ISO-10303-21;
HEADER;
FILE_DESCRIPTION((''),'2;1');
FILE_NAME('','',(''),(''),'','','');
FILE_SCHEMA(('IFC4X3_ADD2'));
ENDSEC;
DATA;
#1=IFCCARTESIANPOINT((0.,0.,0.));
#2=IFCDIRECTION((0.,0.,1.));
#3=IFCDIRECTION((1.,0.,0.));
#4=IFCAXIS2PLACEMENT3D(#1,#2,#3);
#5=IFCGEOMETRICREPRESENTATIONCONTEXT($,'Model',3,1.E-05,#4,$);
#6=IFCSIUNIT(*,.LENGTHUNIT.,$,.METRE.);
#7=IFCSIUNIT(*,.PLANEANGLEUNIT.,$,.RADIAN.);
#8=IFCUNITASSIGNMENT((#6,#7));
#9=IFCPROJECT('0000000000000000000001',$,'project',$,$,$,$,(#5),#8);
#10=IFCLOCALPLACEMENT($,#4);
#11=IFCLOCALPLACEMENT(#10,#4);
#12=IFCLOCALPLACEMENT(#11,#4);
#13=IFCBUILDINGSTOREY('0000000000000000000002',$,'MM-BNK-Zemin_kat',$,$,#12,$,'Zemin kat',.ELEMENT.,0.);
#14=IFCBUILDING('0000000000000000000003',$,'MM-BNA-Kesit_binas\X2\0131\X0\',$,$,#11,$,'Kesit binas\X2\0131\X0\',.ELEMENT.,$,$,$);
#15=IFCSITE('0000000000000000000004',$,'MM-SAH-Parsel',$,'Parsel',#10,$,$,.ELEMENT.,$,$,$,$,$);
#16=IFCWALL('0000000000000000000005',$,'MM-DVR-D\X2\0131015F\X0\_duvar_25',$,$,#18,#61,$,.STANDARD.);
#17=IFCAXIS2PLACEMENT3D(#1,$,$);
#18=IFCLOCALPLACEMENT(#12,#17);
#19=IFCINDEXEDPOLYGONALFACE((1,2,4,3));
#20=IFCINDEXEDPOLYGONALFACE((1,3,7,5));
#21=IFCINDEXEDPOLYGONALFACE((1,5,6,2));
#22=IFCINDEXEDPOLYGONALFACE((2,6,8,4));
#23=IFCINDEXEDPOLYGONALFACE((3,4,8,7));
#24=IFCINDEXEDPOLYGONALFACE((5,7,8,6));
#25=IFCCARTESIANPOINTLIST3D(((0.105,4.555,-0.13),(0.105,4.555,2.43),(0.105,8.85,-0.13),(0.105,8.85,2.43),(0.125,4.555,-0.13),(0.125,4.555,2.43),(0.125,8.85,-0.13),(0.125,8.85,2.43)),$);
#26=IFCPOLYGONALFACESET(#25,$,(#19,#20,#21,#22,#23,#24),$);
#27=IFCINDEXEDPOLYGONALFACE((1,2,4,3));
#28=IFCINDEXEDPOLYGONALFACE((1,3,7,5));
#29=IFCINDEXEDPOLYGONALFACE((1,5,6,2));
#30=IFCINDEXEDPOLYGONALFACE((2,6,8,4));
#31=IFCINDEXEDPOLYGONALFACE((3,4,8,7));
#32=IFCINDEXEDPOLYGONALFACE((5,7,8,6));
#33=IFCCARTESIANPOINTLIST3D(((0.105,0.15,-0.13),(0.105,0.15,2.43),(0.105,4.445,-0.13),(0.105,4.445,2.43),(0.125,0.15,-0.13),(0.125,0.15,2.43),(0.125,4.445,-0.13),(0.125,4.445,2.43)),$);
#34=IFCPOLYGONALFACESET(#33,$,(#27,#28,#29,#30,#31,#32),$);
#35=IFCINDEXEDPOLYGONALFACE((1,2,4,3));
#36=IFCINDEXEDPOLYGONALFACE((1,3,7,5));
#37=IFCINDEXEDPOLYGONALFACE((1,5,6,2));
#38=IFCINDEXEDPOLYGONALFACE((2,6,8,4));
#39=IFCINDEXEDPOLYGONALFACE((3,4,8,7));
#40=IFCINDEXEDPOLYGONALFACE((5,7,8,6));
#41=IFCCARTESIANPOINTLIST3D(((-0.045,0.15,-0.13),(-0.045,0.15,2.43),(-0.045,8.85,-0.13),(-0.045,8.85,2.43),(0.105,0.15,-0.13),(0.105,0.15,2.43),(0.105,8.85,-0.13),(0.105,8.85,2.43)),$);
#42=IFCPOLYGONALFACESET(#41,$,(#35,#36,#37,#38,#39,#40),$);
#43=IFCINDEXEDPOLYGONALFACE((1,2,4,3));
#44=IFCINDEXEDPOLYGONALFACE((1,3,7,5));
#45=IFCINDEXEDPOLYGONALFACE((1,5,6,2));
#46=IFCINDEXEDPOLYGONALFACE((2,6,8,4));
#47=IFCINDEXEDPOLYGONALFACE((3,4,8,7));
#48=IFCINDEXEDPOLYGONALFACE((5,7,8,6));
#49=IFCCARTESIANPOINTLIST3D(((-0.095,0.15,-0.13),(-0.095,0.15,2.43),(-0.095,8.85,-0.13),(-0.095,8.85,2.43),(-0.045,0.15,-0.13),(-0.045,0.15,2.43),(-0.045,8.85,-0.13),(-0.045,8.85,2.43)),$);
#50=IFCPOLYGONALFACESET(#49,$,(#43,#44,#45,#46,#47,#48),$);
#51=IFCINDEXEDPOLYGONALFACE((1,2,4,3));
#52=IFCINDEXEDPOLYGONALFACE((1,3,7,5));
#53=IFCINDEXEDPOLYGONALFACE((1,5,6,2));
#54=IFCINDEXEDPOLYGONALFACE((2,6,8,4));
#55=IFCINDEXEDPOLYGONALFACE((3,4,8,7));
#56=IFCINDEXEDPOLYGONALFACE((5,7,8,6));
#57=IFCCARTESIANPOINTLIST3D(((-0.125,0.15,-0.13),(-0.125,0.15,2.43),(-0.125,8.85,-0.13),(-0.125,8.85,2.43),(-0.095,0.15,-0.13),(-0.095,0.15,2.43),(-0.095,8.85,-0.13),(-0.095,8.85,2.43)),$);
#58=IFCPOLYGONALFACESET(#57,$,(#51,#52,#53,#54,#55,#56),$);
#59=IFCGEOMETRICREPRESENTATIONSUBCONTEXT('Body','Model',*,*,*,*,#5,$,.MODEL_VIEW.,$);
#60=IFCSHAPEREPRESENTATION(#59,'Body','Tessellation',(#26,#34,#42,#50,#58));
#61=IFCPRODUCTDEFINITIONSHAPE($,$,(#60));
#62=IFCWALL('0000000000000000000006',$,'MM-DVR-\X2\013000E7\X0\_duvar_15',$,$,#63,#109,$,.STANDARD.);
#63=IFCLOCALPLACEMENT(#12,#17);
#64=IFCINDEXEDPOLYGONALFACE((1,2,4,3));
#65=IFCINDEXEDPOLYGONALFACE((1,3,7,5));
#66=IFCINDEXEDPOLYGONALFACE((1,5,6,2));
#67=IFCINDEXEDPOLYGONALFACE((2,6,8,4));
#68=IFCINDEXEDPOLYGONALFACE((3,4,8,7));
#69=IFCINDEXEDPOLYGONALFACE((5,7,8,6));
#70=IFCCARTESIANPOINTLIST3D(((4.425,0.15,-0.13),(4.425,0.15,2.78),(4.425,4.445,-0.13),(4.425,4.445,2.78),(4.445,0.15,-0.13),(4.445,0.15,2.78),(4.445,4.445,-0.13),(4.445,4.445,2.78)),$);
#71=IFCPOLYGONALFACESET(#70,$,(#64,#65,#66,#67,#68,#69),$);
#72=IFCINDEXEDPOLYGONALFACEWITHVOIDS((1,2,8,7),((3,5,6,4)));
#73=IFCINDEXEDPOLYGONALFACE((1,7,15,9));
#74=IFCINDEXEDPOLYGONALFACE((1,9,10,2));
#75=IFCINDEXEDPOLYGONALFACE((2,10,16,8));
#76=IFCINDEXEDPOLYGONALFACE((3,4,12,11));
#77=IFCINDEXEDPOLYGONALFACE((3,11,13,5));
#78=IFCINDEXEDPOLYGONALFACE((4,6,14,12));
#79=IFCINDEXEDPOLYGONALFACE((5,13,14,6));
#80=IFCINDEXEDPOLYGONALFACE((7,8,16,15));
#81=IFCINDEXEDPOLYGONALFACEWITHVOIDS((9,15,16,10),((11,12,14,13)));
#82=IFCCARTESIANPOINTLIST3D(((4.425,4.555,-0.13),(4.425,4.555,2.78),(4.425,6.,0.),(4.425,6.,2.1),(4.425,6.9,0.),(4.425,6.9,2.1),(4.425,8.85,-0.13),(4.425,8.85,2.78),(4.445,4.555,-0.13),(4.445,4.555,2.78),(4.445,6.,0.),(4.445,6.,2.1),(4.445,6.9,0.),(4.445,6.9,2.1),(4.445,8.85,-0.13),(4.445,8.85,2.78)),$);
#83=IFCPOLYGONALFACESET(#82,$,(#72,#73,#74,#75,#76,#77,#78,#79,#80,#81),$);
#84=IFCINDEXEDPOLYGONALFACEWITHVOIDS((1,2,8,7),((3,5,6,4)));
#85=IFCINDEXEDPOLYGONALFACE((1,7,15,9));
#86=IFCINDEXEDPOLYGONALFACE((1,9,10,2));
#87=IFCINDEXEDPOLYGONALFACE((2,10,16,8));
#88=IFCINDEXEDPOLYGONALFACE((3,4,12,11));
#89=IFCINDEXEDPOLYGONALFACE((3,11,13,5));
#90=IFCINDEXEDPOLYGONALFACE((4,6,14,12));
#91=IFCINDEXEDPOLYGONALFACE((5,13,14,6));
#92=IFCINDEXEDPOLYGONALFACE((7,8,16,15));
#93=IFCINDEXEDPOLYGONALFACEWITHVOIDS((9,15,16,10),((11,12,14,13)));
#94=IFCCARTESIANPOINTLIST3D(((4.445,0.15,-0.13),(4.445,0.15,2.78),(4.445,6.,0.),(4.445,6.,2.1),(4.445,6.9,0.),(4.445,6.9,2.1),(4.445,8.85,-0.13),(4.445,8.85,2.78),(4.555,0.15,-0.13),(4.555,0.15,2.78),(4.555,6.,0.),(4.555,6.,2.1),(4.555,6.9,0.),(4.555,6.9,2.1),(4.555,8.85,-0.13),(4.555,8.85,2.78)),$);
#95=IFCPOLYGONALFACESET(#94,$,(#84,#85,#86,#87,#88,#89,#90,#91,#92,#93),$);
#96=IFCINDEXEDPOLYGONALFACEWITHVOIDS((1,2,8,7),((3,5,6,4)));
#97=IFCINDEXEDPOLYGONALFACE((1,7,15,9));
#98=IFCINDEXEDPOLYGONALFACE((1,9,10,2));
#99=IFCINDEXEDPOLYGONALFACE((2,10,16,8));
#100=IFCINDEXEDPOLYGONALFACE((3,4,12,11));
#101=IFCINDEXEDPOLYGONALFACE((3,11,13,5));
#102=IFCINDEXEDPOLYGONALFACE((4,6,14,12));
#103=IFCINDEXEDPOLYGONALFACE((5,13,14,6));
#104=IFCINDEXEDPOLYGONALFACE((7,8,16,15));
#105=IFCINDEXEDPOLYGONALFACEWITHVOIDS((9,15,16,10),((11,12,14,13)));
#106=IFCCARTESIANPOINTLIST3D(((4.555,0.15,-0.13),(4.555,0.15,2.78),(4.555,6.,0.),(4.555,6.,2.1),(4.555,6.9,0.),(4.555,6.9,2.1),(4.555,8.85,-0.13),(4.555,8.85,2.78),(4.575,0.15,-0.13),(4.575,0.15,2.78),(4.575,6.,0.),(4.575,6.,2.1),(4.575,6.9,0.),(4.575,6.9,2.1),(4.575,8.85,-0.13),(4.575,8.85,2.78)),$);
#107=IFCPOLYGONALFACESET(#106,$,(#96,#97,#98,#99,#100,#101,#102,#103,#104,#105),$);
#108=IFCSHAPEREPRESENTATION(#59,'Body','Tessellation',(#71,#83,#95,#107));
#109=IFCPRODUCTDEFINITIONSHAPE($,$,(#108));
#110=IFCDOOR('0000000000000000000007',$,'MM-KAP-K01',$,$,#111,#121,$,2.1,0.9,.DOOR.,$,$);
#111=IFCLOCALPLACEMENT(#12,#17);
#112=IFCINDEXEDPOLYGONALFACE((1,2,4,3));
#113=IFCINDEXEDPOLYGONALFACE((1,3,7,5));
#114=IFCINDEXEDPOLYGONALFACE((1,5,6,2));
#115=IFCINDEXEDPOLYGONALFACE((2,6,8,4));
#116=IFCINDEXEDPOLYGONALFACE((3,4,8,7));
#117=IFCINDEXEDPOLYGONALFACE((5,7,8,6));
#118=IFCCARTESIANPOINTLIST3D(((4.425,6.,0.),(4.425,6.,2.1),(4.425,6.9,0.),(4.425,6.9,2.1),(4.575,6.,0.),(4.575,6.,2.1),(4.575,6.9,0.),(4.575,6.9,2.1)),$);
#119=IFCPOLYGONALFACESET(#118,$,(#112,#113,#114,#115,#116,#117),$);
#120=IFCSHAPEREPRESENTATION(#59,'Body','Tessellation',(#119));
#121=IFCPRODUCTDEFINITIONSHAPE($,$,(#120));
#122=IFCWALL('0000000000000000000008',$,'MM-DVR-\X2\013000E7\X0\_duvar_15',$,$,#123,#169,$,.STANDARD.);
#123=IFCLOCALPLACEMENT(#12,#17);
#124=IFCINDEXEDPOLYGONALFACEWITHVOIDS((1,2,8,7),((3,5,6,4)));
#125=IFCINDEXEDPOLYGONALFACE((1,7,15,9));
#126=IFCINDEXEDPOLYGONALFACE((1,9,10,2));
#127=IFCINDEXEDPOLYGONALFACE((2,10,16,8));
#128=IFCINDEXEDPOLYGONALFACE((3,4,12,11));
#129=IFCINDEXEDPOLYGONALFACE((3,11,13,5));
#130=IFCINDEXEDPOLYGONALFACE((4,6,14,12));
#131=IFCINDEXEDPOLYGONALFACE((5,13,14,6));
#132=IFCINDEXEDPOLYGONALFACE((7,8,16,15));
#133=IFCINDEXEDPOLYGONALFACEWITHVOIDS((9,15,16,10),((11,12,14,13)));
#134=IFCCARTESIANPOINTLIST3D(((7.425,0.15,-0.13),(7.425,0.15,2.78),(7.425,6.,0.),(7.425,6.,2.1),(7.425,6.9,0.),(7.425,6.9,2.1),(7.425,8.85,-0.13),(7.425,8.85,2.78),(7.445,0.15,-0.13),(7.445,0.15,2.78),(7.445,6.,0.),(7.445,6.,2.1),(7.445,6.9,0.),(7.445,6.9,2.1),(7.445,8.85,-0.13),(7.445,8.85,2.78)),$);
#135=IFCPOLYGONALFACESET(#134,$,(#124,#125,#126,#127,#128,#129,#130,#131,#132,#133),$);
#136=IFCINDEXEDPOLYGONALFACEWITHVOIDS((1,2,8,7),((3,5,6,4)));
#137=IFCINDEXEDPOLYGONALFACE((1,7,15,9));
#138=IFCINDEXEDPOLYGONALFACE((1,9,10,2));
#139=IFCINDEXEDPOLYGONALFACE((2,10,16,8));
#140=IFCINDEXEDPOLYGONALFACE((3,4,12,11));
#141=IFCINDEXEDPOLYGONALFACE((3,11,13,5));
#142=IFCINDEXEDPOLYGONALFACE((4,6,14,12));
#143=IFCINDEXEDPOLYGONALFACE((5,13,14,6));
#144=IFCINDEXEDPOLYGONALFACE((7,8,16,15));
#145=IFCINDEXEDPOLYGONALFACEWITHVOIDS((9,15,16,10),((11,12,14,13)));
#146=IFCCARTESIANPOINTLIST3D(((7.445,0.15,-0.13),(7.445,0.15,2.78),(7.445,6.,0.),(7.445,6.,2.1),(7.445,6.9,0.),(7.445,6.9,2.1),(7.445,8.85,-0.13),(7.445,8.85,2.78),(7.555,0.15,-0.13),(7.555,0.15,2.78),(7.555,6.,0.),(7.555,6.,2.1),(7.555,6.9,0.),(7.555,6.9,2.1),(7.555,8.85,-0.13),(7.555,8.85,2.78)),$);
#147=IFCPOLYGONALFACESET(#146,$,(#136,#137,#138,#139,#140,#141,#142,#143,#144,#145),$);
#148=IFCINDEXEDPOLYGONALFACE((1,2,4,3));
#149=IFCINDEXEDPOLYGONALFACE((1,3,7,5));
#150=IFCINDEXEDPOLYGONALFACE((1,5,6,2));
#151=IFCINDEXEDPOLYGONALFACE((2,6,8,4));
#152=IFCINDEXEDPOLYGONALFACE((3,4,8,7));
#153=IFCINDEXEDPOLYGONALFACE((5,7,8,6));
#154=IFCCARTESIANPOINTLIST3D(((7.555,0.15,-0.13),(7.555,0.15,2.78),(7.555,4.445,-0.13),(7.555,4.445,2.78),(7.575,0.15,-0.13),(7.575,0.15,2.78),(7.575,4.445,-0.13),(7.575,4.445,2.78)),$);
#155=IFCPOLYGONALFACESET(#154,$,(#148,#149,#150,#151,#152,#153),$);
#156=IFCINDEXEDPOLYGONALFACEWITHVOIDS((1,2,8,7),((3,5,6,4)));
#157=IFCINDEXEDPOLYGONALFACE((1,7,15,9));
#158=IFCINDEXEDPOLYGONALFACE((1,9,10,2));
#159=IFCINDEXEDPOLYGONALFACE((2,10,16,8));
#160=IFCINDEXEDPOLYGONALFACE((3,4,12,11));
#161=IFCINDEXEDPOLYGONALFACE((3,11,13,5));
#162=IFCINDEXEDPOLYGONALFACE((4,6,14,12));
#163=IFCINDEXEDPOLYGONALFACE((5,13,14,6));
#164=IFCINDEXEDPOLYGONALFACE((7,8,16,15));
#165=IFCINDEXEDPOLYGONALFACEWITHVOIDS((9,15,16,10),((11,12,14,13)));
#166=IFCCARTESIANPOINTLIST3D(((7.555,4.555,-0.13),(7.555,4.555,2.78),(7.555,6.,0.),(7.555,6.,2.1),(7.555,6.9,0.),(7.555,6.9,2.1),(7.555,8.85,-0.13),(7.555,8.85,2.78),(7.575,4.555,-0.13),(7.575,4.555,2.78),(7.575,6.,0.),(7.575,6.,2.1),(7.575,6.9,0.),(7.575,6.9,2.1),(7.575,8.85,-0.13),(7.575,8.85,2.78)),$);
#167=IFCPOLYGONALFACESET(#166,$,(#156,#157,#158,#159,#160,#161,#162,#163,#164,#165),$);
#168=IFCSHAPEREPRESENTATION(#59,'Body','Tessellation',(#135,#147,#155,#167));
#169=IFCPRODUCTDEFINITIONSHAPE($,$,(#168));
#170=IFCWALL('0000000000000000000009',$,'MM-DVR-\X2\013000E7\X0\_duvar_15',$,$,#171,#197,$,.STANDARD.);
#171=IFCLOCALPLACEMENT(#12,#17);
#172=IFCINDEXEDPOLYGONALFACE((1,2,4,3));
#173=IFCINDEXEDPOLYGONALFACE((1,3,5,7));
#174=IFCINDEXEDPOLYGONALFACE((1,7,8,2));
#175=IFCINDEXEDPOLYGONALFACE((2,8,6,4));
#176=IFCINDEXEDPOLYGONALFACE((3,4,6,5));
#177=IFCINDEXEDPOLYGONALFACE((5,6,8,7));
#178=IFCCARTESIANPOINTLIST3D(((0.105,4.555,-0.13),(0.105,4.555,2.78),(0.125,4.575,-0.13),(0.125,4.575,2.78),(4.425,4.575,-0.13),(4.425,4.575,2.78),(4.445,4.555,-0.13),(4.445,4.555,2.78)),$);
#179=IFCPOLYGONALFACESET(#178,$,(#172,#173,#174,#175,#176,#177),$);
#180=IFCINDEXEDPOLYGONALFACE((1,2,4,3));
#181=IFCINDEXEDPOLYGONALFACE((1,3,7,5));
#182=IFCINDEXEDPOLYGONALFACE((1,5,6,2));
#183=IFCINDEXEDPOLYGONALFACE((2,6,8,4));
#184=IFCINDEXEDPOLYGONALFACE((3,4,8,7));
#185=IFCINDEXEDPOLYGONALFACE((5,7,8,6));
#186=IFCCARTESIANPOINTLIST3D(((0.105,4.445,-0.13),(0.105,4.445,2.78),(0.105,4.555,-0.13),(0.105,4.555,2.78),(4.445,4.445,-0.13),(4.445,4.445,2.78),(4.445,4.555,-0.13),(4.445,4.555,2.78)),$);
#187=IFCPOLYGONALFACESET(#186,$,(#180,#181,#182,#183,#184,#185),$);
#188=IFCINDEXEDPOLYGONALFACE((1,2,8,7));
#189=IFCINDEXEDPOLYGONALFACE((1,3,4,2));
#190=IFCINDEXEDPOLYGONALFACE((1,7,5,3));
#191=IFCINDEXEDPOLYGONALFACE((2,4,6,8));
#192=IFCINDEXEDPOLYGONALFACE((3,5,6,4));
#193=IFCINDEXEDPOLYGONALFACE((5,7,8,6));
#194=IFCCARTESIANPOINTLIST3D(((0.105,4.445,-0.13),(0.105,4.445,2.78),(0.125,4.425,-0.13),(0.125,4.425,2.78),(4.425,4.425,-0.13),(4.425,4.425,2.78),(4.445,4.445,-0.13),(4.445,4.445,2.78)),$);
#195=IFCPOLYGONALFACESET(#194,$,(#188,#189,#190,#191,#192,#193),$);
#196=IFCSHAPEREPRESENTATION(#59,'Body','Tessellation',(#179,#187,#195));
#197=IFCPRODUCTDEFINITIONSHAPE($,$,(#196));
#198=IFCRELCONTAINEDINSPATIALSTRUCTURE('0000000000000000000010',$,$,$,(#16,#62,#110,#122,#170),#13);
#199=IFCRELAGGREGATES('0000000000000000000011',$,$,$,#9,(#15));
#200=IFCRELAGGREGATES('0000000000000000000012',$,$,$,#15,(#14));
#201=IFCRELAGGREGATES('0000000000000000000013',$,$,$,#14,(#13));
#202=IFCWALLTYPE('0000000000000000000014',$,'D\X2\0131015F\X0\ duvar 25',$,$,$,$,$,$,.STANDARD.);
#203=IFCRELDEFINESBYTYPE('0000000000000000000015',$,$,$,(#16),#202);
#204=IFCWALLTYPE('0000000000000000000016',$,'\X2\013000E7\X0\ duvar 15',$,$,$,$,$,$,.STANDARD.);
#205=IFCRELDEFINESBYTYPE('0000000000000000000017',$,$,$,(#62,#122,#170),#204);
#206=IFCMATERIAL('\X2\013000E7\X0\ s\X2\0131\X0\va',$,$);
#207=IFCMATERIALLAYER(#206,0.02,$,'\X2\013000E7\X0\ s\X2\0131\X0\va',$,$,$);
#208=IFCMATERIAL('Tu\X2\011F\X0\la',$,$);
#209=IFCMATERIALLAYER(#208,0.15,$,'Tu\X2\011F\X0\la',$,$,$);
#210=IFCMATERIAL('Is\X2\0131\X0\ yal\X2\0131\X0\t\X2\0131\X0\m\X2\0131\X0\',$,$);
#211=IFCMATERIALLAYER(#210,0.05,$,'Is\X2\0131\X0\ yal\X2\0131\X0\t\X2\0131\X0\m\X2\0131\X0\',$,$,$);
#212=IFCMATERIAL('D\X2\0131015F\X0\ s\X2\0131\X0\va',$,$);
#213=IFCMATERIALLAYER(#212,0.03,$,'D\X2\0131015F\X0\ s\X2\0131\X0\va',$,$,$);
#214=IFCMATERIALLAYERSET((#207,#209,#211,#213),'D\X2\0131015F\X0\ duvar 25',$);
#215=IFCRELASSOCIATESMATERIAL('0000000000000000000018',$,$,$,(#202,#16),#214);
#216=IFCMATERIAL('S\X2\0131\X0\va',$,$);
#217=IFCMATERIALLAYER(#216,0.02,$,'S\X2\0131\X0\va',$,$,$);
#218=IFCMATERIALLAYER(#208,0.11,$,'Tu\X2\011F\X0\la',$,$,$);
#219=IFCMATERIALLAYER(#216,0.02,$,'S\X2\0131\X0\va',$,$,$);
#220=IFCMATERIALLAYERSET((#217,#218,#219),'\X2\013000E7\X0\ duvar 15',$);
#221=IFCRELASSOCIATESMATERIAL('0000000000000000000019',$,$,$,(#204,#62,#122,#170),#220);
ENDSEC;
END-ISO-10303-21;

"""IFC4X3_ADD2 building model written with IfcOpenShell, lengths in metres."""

from ifc_helpers import new_model, si_unit, frame, origin, origin_with_axes, place, context, subcontext, project, spatial, polyline, outline, extrude, material, layer, layer_set, type_object, element, fill, save


model = new_model("IFC4X3_ADD2")

# Units and contexts
model_context = context("Model", 3, precision=1e-05, world=origin_with_axes())
body_context = subcontext(model_context, "Body", "Model", "MODEL_VIEW")
ifc_project = project(units=[si_unit("LENGTHUNIT", "METRE"), si_unit("PLANEANGLEUNIT", "RADIAN")], contexts=[model_context])

# Site, building, storey
site_placement = place(None, origin_with_axes())
site = spatial("IfcSite", under=ifc_project, at=site_placement, Name="MM-SAH-Parsel", ObjectType="Parsel", CompositionType="ELEMENT")
building_placement = place(site_placement, origin_with_axes())
building = spatial("IfcBuilding", under=site, at=building_placement, Name="MM-BNA-Kesit_binası", LongName="Kesit binası", CompositionType="ELEMENT")
storey_placement = place(building_placement, origin_with_axes())
storey = spatial("IfcBuildingStorey", under=building, at=storey_placement, Name="MM-BNK-Zemin_kat", LongName="Zemin kat", CompositionType="ELEMENT", Elevation=0.0)

# Shared definitions
ifc_material_1 = material(Name="İç sıva")
ifc_layer_1 = layer(ifc_material_1, 0.02, Name="İç sıva")
ifc_material_2 = material(Name="Tuğla")
ifc_layer_2 = layer(ifc_material_2, 0.15, Name="Tuğla")
ifc_material_3 = material(Name="Isı yalıtımı")
ifc_layer_3 = layer(ifc_material_3, 0.05, Name="Isı yalıtımı")
ifc_material_4 = material(Name="Dış sıva")
ifc_layer_4 = layer(ifc_material_4, 0.03, Name="Dış sıva")
ifc_layer_set_1 = layer_set([ifc_layer_1, ifc_layer_2, ifc_layer_3, ifc_layer_4], Name="Dış duvar 25")
wall_type_1 = type_object("IfcWallType", Name="Dış duvar 25", PredefinedType="STANDARD", material=ifc_layer_set_1)

# Wall
wall_1_placement = place(storey_placement, origin_with_axes())
element("IfcWall", 1, at=wall_1_placement, inside=storey, type_object=wall_type_1, material=ifc_layer_set_1, Name="MM-DVR-Dış_duvar_25", PredefinedType="STANDARD", context=body_context, shape_type="SweptSolid", body=[
    extrude(outline(polyline([(0.105, 8.85), (0.105, 4.555), (0.125, 4.555), (0.125, 8.85), (0.105, 8.85)])), frame((0.0, 0.0, -0.13)), (0.0, 0.0, 1.0), 2.56),
    extrude(outline(polyline([(0.105, 4.445), (0.105, 0.15), (0.125, 0.15), (0.125, 4.445), (0.105, 4.445)])), frame((0.0, 0.0, -0.13)), (0.0, 0.0, 1.0), 2.56),
    extrude(outline(polyline([(-0.045, 8.85), (-0.045, 0.15), (0.105, 0.15), (0.105, 8.85), (-0.045, 8.85)])), frame((0.0, 0.0, -0.13)), (0.0, 0.0, 1.0), 2.56),
    extrude(outline(polyline([(-0.095, 8.85), (-0.095, 0.15), (-0.045, 0.15), (-0.045, 8.85), (-0.095, 8.85)])), frame((0.0, 0.0, -0.13)), (0.0, 0.0, 1.0), 2.56),
    extrude(outline(polyline([(-0.125, 8.85), (-0.125, 0.15), (-0.095, 0.15), (-0.095, 8.85), (-0.125, 8.85)])), frame((0.0, 0.0, -0.13)), (0.0, 0.0, 1.0), 2.56),
])

# Wall, opening, door
ifc_material_5 = material(Name="Sıva")
ifc_layer_5 = layer(ifc_material_5, 0.02, Name="Sıva")
ifc_layer_6 = layer(ifc_material_2, 0.11, Name="Tuğla")
ifc_layer_7 = layer(ifc_material_5, 0.02, Name="Sıva")
ifc_layer_set_2 = layer_set([ifc_layer_5, ifc_layer_6, ifc_layer_7], Name="İç duvar 15")
wall_type_2 = type_object("IfcWallType", Name="İç duvar 15", PredefinedType="STANDARD", material=ifc_layer_set_2)
wall_2_placement = place(storey_placement, origin_with_axes())
wall_2 = element("IfcWall", 2, at=wall_2_placement, inside=storey, type_object=wall_type_2, material=ifc_layer_set_2, Name="MM-DVR-İç_duvar_15", PredefinedType="STANDARD", context=body_context, shape_type="SweptSolid", body=[
    extrude(outline(polyline([(4.445, 0.15), (4.445, 4.445), (4.425, 4.445), (4.425, 0.15), (4.445, 0.15)])), frame((0.0, 0.0, -0.13)), (0.0, 0.0, 1.0), 2.91),
    extrude(outline(polyline([(4.445, 4.555), (4.445, 8.85), (4.425, 8.85), (4.425, 4.555), (4.445, 4.555)])), frame((0.0, 0.0, -0.13)), (0.0, 0.0, 1.0), 2.91),
    extrude(outline(polyline([(4.555, 0.15), (4.555, 8.85), (4.445, 8.85), (4.445, 0.15), (4.555, 0.15)])), frame((0.0, 0.0, -0.13)), (0.0, 0.0, 1.0), 2.91),
    extrude(outline(polyline([(4.575, 0.15), (4.575, 8.85), (4.555, 8.85), (4.555, 0.15), (4.575, 0.15)])), frame((0.0, 0.0, -0.13)), (0.0, 0.0, 1.0), 2.91),
])
opening_1_placement = place(storey_placement, origin_with_axes())
opening_1 = element("IfcOpeningElement", 3, at=opening_1_placement, cuts=wall_2, PredefinedType="OPENING", context=body_context, shape_type="SweptSolid", body=[
    extrude(outline(polyline([(4.425, 6.0), (4.425, 6.9), (4.575, 6.9), (4.575, 6.0), (4.425, 6.0)])), origin(), (0.0, 0.0, 1.0), 2.1),
])
door_1_placement = place(storey_placement, origin_with_axes())
door_1 = element("IfcDoor", 4, at=door_1_placement, inside=storey, Name="MM-KAP-K01", OverallHeight=2.1, OverallWidth=0.9, PredefinedType="DOOR", context=body_context, shape_type="SweptSolid", body=[
    extrude(outline(polyline([(4.425, 6.0), (4.425, 6.9), (4.575, 6.9), (4.575, 6.0), (4.425, 6.0)])), origin(), (0.0, 0.0, 1.0), 2.1),
])
fill(opening_1, door_1)

# Wall, opening
wall_3_placement = place(storey_placement, origin_with_axes())
wall_3 = element("IfcWall", 5, at=wall_3_placement, inside=storey, type_object=wall_type_2, material=ifc_layer_set_2, Name="MM-DVR-İç_duvar_15", PredefinedType="STANDARD", context=body_context, shape_type="SweptSolid", body=[
    extrude(outline(polyline([(7.445, 0.15), (7.445, 8.85), (7.425, 8.85), (7.425, 0.15), (7.445, 0.15)])), frame((0.0, 0.0, -0.13)), (0.0, 0.0, 1.0), 2.91),
    extrude(outline(polyline([(7.555, 0.15), (7.555, 8.85), (7.445, 8.85), (7.445, 0.15), (7.555, 0.15)])), frame((0.0, 0.0, -0.13)), (0.0, 0.0, 1.0), 2.91),
    extrude(outline(polyline([(7.575, 0.15), (7.575, 4.445), (7.555, 4.445), (7.555, 0.15), (7.575, 0.15)])), frame((0.0, 0.0, -0.13)), (0.0, 0.0, 1.0), 2.91),
    extrude(outline(polyline([(7.575, 4.555), (7.575, 8.85), (7.555, 8.85), (7.555, 4.555), (7.575, 4.555)])), frame((0.0, 0.0, -0.13)), (0.0, 0.0, 1.0), 2.91),
])
opening_2_placement = place(storey_placement, origin_with_axes())
element("IfcOpeningElement", 6, at=opening_2_placement, cuts=wall_3, PredefinedType="OPENING", context=body_context, shape_type="SweptSolid", body=[
    extrude(outline(polyline([(7.425, 6.0), (7.425, 6.9), (7.575, 6.9), (7.575, 6.0), (7.425, 6.0)])), origin(), (0.0, 0.0, 1.0), 2.1),
])

# Wall
wall_4_placement = place(storey_placement, origin_with_axes())
element("IfcWall", 7, at=wall_4_placement, inside=storey, type_object=wall_type_2, material=ifc_layer_set_2, Name="MM-DVR-İç_duvar_15", PredefinedType="STANDARD", context=body_context, shape_type="SweptSolid", body=[
    extrude(outline(polyline([(0.125, 4.575), (4.425, 4.575), (4.445, 4.555), (0.105, 4.555), (0.125, 4.575)])), frame((0.0, 0.0, -0.13)), (0.0, 0.0, 1.0), 2.91),
    extrude(outline(polyline([(0.105, 4.555), (4.445, 4.555), (4.445, 4.445), (0.105, 4.445), (0.105, 4.555)])), frame((0.0, 0.0, -0.13)), (0.0, 0.0, 1.0), 2.91),
    extrude(outline(polyline([(0.105, 4.445), (4.445, 4.445), (4.425, 4.425), (0.125, 4.425), (0.105, 4.445)])), frame((0.0, 0.0, -0.13)), (0.0, 0.0, 1.0), 2.91),
])

save(model, "model.ifc")
